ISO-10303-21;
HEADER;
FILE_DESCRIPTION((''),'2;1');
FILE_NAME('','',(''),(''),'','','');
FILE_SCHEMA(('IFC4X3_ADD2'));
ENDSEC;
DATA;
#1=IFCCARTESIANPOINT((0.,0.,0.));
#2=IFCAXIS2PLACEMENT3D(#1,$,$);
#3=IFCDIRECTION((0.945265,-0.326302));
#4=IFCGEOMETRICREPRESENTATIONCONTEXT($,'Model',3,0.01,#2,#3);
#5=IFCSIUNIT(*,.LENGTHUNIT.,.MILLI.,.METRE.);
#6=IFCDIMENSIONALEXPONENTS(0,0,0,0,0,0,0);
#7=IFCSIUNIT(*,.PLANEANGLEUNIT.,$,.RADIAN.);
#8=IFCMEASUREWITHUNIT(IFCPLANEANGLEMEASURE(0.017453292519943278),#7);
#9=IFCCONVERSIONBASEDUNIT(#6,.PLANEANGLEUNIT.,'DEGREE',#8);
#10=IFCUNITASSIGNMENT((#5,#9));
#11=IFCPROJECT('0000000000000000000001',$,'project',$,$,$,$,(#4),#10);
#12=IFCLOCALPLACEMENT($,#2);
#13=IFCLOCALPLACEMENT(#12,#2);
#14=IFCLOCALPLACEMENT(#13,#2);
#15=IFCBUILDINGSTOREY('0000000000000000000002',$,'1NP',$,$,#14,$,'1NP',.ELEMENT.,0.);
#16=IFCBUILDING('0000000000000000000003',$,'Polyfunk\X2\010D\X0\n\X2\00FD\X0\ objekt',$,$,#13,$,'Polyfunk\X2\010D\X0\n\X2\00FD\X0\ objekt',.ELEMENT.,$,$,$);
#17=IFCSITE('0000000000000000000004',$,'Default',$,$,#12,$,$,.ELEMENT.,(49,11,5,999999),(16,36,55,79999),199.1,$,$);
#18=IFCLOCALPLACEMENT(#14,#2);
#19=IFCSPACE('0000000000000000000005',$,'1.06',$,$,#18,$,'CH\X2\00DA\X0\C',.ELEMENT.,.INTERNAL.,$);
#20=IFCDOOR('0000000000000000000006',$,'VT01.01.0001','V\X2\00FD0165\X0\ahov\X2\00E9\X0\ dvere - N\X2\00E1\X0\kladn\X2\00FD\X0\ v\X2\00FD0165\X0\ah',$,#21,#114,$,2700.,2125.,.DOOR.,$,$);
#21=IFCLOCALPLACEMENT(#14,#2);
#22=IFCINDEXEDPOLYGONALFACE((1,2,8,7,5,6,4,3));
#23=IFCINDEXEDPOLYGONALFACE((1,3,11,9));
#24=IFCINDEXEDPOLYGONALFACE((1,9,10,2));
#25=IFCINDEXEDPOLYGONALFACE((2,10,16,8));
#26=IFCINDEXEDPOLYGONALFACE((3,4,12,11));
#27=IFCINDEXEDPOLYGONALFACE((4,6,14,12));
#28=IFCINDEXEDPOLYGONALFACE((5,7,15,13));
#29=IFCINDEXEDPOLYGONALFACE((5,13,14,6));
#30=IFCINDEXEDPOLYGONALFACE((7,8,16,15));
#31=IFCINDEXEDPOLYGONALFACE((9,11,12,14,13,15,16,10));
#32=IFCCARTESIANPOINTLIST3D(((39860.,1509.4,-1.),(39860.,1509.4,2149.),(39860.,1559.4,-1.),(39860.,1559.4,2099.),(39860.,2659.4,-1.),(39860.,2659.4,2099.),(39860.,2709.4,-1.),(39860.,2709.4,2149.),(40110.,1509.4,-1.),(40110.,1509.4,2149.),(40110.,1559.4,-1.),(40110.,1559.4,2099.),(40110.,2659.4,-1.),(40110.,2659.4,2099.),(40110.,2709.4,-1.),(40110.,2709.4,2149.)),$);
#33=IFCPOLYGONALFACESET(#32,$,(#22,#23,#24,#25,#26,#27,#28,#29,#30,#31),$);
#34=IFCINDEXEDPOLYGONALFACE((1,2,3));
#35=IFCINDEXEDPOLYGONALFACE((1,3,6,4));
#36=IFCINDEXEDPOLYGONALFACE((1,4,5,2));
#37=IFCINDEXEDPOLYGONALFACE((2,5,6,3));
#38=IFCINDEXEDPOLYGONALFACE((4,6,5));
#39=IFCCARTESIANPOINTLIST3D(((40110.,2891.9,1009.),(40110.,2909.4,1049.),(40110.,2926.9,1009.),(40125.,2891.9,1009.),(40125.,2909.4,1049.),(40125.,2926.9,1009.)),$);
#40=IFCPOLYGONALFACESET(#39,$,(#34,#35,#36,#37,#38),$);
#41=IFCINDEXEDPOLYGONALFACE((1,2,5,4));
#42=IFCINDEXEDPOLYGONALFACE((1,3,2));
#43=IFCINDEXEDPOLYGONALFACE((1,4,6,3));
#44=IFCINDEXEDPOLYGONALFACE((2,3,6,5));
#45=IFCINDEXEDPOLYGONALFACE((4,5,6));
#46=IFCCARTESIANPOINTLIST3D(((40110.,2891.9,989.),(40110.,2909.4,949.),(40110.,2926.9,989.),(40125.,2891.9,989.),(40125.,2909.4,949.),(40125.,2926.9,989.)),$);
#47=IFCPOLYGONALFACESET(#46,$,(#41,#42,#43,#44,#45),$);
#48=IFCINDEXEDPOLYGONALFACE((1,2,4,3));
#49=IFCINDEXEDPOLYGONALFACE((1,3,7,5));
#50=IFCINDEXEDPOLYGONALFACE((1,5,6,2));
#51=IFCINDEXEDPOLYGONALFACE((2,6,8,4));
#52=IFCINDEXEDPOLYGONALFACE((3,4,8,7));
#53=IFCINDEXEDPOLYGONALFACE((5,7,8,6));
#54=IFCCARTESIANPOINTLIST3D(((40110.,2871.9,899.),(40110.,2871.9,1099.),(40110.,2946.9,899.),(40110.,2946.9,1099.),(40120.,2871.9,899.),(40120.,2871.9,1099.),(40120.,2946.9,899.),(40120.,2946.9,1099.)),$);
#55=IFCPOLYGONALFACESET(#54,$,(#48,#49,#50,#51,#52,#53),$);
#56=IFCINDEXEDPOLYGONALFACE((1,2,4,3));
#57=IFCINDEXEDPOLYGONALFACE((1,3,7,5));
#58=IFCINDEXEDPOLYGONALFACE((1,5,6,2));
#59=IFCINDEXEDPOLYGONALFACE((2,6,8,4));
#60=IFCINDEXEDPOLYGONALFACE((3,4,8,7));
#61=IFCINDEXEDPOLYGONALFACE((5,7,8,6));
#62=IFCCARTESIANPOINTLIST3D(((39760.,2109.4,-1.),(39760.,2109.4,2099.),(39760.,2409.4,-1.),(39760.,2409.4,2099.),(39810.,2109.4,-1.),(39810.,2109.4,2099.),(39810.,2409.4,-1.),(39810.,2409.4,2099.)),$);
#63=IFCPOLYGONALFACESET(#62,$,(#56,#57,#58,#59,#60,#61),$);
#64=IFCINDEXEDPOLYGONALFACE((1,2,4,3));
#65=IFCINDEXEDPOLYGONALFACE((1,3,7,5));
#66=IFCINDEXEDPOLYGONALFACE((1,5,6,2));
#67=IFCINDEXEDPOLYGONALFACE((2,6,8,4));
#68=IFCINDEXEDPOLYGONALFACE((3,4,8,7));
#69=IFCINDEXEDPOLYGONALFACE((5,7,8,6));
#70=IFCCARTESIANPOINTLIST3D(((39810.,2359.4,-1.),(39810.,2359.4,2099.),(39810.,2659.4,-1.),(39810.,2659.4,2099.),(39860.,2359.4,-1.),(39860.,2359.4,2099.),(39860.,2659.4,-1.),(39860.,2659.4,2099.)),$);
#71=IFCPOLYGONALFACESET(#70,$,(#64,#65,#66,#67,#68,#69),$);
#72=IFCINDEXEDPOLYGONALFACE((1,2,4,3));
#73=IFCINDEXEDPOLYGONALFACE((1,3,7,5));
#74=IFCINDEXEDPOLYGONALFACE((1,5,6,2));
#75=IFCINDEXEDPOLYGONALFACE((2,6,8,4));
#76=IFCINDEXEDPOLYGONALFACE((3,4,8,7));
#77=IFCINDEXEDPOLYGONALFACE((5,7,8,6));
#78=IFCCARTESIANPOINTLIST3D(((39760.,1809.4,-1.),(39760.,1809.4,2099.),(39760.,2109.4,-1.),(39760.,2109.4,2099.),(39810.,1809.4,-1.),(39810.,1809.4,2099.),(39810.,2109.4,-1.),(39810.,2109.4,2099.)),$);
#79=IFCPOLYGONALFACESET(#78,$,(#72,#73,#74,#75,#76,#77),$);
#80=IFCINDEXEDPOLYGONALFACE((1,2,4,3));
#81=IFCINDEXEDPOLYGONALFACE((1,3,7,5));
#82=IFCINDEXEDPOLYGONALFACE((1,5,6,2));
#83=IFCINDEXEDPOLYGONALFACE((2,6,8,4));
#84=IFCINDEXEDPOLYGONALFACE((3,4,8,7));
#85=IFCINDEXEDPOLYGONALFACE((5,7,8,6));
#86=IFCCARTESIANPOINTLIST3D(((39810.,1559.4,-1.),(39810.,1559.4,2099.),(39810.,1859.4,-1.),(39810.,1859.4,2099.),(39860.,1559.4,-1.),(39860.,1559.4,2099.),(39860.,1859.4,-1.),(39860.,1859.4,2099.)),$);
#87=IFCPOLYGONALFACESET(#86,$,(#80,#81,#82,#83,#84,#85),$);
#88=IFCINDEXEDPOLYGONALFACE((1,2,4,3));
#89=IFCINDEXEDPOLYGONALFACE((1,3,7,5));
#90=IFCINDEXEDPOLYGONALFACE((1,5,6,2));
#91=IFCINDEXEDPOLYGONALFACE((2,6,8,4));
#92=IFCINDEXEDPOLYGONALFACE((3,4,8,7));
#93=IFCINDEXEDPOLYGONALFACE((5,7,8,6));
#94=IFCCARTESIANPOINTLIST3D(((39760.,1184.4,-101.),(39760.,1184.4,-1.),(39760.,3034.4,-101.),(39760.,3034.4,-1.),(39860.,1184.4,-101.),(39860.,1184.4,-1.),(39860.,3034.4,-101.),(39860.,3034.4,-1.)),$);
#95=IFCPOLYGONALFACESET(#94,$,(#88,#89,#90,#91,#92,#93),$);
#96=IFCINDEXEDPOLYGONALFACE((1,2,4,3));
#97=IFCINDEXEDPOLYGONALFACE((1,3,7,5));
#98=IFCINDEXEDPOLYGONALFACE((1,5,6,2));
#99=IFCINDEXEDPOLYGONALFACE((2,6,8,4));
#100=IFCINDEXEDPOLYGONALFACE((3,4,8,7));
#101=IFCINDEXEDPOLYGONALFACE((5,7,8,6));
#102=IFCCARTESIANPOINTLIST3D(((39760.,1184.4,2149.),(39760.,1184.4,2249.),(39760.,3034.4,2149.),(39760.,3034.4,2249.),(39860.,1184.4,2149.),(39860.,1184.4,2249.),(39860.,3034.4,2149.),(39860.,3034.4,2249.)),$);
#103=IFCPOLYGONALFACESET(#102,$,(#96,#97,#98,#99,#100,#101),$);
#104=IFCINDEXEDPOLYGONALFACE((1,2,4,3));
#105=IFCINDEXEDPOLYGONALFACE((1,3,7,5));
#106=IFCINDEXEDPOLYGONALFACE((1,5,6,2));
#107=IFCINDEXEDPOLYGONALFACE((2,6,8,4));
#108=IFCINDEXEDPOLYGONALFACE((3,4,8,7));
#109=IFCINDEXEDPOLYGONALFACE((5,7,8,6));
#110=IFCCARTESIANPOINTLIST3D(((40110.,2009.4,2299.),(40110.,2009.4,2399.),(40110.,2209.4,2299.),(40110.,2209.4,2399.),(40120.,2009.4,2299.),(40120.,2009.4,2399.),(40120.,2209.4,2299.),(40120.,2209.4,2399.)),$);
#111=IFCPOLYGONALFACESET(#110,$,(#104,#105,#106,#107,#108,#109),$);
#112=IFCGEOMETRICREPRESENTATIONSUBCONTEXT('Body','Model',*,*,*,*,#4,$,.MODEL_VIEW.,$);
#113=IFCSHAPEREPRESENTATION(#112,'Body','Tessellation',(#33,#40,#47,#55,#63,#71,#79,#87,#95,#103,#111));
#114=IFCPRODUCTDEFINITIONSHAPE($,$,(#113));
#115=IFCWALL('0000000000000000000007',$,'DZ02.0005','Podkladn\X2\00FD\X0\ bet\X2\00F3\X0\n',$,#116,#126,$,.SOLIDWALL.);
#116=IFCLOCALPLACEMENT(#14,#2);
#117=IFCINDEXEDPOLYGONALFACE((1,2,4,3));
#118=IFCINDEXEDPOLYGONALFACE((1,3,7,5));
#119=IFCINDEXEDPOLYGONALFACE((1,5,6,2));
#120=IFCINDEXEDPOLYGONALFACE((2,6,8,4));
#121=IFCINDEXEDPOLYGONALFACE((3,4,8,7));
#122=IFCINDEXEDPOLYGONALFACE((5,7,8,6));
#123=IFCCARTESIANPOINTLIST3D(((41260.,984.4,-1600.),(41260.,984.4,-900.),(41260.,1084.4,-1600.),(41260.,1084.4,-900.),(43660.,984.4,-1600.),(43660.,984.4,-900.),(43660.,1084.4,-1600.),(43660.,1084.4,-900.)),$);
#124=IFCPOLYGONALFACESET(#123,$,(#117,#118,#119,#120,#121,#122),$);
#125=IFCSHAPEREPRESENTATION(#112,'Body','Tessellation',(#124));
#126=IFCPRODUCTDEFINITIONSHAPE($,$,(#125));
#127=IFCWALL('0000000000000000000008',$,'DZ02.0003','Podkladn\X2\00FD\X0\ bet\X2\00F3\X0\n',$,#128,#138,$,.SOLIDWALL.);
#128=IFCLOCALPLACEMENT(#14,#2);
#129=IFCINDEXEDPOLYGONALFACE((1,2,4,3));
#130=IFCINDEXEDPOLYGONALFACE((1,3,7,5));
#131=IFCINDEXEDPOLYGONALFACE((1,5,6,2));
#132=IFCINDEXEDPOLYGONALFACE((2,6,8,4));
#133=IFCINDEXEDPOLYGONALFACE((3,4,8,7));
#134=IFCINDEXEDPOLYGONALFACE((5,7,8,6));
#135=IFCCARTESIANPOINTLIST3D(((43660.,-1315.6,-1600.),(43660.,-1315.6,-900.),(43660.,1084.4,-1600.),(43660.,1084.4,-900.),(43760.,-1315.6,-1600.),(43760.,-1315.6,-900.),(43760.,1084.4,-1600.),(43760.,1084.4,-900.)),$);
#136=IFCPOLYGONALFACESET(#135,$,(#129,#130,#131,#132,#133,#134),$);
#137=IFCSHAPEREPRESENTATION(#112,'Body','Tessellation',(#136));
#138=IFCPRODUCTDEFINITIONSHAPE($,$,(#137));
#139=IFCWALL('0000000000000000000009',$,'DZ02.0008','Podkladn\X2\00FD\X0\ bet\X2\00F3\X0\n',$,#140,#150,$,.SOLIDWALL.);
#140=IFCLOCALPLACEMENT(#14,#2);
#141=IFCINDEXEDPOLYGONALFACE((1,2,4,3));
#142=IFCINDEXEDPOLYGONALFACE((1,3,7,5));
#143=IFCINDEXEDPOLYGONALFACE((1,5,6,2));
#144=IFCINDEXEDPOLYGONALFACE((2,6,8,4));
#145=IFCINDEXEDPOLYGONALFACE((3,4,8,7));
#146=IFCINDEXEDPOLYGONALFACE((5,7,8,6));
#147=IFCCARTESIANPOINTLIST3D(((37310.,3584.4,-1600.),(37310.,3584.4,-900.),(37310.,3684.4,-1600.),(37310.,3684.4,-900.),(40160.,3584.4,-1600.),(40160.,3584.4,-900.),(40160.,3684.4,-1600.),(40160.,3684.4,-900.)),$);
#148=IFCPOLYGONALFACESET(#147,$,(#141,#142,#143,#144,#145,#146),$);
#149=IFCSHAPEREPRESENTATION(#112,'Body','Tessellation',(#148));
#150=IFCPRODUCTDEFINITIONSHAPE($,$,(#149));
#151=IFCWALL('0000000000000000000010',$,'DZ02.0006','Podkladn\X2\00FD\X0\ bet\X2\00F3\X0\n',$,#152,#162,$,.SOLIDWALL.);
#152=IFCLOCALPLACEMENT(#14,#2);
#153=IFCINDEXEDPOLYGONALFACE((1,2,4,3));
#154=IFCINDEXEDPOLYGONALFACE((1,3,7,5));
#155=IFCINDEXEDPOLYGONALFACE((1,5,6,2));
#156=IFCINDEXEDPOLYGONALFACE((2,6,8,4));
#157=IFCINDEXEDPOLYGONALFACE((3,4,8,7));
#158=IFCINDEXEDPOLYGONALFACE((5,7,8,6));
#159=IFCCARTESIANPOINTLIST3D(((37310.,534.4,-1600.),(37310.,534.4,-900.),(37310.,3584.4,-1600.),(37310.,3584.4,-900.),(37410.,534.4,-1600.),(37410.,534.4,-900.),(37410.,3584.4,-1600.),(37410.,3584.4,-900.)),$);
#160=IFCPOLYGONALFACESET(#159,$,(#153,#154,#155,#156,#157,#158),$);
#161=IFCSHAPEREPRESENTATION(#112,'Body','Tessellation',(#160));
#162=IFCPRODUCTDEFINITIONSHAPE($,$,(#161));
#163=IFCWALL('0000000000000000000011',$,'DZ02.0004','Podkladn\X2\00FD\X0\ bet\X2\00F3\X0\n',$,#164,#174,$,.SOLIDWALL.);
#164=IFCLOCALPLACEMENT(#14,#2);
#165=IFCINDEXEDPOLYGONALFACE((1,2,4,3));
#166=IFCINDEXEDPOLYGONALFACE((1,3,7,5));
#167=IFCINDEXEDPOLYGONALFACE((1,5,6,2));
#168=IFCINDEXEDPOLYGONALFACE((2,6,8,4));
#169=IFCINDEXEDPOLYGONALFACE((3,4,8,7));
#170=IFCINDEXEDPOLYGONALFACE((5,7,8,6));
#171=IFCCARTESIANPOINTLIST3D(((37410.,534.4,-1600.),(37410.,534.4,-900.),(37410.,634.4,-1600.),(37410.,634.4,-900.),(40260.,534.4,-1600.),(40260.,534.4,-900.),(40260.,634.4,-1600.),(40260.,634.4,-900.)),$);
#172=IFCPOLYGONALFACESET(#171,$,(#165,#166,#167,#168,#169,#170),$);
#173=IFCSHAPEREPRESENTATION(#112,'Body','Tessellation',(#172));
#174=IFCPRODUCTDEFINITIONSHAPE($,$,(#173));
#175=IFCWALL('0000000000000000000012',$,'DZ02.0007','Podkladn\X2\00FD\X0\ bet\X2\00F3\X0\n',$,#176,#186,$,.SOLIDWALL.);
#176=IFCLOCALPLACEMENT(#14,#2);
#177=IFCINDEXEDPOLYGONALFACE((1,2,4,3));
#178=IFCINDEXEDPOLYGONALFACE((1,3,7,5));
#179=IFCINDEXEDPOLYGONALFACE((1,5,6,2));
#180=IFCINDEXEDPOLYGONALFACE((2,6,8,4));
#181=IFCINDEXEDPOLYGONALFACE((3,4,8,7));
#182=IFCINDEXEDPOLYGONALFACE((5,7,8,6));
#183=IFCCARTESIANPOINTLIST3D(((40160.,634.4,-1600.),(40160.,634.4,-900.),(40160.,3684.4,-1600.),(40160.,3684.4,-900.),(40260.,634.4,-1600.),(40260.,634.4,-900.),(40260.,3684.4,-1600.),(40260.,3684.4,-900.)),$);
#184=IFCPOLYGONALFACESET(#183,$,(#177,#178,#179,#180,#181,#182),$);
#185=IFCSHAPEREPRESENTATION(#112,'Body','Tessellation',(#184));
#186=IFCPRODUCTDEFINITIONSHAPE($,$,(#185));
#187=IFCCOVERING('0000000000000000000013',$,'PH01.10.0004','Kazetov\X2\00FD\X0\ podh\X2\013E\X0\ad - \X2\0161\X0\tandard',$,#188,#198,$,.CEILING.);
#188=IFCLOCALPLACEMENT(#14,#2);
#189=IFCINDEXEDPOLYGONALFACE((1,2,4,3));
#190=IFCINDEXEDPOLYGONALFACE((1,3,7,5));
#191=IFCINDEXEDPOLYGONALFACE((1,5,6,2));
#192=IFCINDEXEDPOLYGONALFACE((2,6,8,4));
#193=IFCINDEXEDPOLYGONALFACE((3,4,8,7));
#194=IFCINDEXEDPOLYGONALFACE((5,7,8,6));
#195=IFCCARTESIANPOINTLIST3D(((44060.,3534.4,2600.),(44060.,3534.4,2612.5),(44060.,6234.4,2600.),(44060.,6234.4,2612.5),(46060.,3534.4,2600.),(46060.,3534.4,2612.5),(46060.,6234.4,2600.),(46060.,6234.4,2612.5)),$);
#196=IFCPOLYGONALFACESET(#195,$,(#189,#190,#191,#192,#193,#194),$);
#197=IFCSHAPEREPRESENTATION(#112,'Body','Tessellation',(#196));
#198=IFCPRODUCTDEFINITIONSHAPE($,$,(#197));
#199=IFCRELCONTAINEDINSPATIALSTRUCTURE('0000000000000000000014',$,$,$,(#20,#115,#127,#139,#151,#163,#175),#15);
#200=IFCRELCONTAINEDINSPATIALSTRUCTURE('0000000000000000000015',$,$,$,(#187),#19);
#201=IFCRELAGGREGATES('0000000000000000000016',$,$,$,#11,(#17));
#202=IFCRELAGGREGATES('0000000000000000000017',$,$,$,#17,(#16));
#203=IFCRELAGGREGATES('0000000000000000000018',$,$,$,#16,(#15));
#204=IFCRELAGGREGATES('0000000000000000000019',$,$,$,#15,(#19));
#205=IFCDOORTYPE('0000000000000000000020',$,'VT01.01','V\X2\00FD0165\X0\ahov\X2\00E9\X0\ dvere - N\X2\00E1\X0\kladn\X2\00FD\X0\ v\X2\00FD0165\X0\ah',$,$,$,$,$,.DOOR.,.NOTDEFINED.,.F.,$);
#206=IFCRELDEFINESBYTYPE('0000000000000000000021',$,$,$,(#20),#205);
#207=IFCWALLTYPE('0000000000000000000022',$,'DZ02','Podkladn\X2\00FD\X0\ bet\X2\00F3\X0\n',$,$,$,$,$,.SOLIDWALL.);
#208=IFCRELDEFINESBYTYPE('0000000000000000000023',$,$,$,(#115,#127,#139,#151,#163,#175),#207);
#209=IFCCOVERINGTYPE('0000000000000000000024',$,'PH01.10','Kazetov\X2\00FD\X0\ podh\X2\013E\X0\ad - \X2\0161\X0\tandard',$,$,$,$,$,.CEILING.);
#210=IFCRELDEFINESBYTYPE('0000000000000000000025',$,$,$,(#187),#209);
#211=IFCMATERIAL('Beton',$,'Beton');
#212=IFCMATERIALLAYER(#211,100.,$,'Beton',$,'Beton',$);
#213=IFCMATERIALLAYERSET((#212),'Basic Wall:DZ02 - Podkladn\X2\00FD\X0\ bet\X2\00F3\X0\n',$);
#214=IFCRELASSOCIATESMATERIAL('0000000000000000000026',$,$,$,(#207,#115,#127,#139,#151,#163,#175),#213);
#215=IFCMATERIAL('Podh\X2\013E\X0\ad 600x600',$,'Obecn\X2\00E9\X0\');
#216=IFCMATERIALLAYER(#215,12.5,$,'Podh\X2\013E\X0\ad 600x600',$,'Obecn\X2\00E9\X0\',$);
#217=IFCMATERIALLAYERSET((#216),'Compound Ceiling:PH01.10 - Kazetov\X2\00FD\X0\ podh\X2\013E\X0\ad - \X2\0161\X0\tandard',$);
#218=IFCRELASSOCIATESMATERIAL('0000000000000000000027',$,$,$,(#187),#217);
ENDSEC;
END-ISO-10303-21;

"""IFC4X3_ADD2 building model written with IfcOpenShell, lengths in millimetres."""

from ifc_helpers import new_model, entity, si_unit, converted_unit, direction, frame, frame_2d, origin, origin_2d_with_axis, place, context, subcontext, project, spatial, polyline, rectangle, outline, extrude, source, transform, mapped, material, layer, layer_set, layer_usage, type_object, type_shapes, element, save


model = new_model("IFC4X3_ADD2")

# Units and contexts
model_context = context("Model", 3, precision=0.01, world=origin(), true_north=direction((0.945265, -0.326302)))
body_context = subcontext(model_context, "Body", "Model", "MODEL_VIEW")
ifc_project = project(units=[si_unit("LENGTHUNIT", "METRE", prefix="MILLI"), converted_unit("PLANEANGLEUNIT", "DEGREE", entity("IfcPlaneAngleMeasure", 0.017453292519943278), si_unit("PLANEANGLEUNIT", "RADIAN"), dimensions=[0, 0, 0, 0, 0, 0, 0])], contexts=[model_context])

# Site, building, storey
site_placement = place(None, origin())
site = spatial("IfcSite", under=ifc_project, at=site_placement, Name="Default", CompositionType="ELEMENT", RefLatitude=(49, 11, 5, 999999), RefLongitude=(16, 36, 55, 79999), RefElevation=199.1)
building_placement = place(site_placement, origin())
building = spatial("IfcBuilding", under=site, at=building_placement, Name="Polyfunkčný objekt", LongName="Polyfunkčný objekt", CompositionType="ELEMENT")
storey_placement = place(building_placement, origin())
storey = spatial("IfcBuildingStorey", under=building, at=storey_placement, Name="1NP", LongName="1NP", CompositionType="ELEMENT", Elevation=0.0)

# Door
door_type_1 = type_object("IfcDoorType", Name="VT01.01", Description="Výťahové dvere - Nákladný výťah", OperationType="NOTDEFINED", ParameterTakesPrecedence=False, PredefinedType="DOOR")
shared_shape_1 = source(origin(), body_context, "Body", "SweptSolid", [
    extrude(outline(polyline([(-1087.5, -600.0), (1062.5, -600.0), (1062.5, -550.0), (-1037.5, -550.0), (-1037.5, 550.0), (1062.5, 550.0), (1062.5, 600.0), (-1087.5, 600.0), (-1087.5, -600.0)])), frame((600.0, 0.0, 1062.5), z_axis=(0.0, 1.0, 0.0), x_axis=(0.0, 0.0, -1.0)), (0.0, 0.0, 1.0), 250.0),
    extrude(outline(polyline([(-24.4, -10.7), (19.2, -10.7), (5.2, 21.4), (-24.4, -10.7)])), frame((1400.0, -15.0, 1023.3), z_axis=(0.0, 1.0, 0.0), x_axis=(0.400819, 0.0, -0.916157)), (0.0, 0.0, 1.0), 15.0),
    extrude(outline(polyline([(-24.4, -10.7), (19.2, -10.7), (5.2, 21.4), (-24.4, -10.7)])), frame((1400.0, -15.0, 976.7), z_axis=(0.0, 1.0, 0.0), x_axis=(-0.400819, 0.0, 0.916157)), (0.0, 0.0, 1.0), 15.0),
    extrude(rectangle(XDim=10.0, YDim=75.0, at=frame_2d((0.0, 0.0), x_axis=(1.0, 0.0))), frame((1400.0, -5.0, 900.0), z_axis=(0.0, 0.0, 1.0), x_axis=(0.0, 1.0, 0.0)), (0.0, 0.0, 1.0), 200.0),
    extrude(rectangle(XDim=50.0, YDim=300.0, at=origin_2d_with_axis()), frame((750.0, 325.0, 0.0), z_axis=(0.0, 0.0, 1.0), x_axis=(0.0, -1.0, 0.0)), (0.0, 0.0, 1.0), 2100.0),
    extrude(rectangle(XDim=50.0, YDim=300.0, at=frame_2d((0.0, 0.0), x_axis=(1.0, 0.0))), frame((1000.0, 275.0, 0.0), z_axis=(0.0, 0.0, 1.0), x_axis=(0.0, -1.0, 0.0)), (0.0, 0.0, 1.0), 2100.0),
    extrude(rectangle(XDim=300.0, YDim=50.0, at=frame_2d((0.0, 0.0), x_axis=(1.0, 0.0))), frame((450.0, 325.0, 0.0), z_axis=(0.0, 0.0, 1.0), x_axis=(-1.0, 0.0, 0.0)), (0.0, 0.0, 1.0), 2100.0),
    extrude(rectangle(XDim=300.0, YDim=50.0, at=frame_2d((0.0, 0.0), x_axis=(1.0, 0.0))), frame((200.0, 275.0, 0.0), z_axis=(0.0, 0.0, 1.0), x_axis=(-1.0, 0.0, 0.0)), (0.0, 0.0, 1.0), 2100.0),
    extrude(rectangle(XDim=1850.0, YDim=100.0, at=frame_2d((0.0, 0.0), x_axis=(1.0, 0.0))), frame((600.0, 300.0, -100.0), z_axis=(0.0, 0.0, 1.0), x_axis=(-1.0, 0.0, 0.0)), (0.0, 0.0, 1.0), 100.0),
    extrude(rectangle(XDim=1850.0, YDim=100.0, at=frame_2d((0.0, 0.0), x_axis=(1.0, 0.0))), frame((600.0, 300.0, 2150.0), z_axis=(0.0, 0.0, 1.0), x_axis=(-1.0, 0.0, 0.0)), (0.0, 0.0, 1.0), 100.0),
    extrude(rectangle(XDim=10.0, YDim=200.0, at=frame_2d((0.0, 0.0), x_axis=(1.0, 0.0))), frame((600.0, -5.0, 2300.0), z_axis=(0.0, 0.0, 1.0), x_axis=(0.0, 1.0, 0.0)), (0.0, 0.0, 1.0), 100.0),
])
type_shapes(door_type_1, [shared_shape_1])
door_1_placement = place(storey_placement, frame((40110.0, 1509.4, -1.0), z_axis=(0.0, 0.0, 1.0), x_axis=(0.0, 1.0, 0.0)))
element("IfcDoor", 1, at=door_1_placement, inside=storey, type_object=door_type_1, Name="VT01.01.0001", Description="Výťahové dvere - Nákladný výťah", OverallHeight=2700.0, OverallWidth=2125.0, PredefinedType="DOOR", context=body_context, shape_type="MappedRepresentation", body=[
    mapped(shared_shape_1, transform((0.0, 0.0, 0.0), scale=1.0)),
])

# Walls
ifc_material_1 = material(Name="Beton", Category="Beton")
ifc_layer_1 = layer(ifc_material_1, 100.0, Name="Beton", Category="Beton")
ifc_layer_set_1 = layer_set([ifc_layer_1], Name="Basic Wall:DZ02 - Podkladný betón")
wall_type_1 = type_object("IfcWallType", Name="DZ02", Description="Podkladný betón", PredefinedType="SOLIDWALL", material=ifc_layer_set_1)
wall_1_placement = place(storey_placement, frame((41260.0, 1034.4, -1600.0)))
element("IfcWall", 2, at=wall_1_placement, inside=storey, type_object=wall_type_1, material=ifc_layer_set_1, Name="DZ02.0005", Description="Podkladný betón", PredefinedType="SOLIDWALL", context=body_context, shape_type="SweptSolid", body=[
    extrude(rectangle(XDim=2400.0, YDim=100.0, at=frame_2d((1200.0, 0.0), x_axis=(-1.0, 0.0))), origin(), (0.0, 0.0, 1.0), 700.0),
])
wall_2_placement = place(storey_placement, frame((43710.0, 1084.4, -1600.0), z_axis=(0.0, 0.0, 1.0), x_axis=(0.0, -1.0, 0.0)))
element("IfcWall", 3, at=wall_2_placement, inside=storey, type_object=wall_type_1, material=ifc_layer_set_1, Name="DZ02.0003", Description="Podkladný betón", PredefinedType="SOLIDWALL", context=body_context, shape_type="SweptSolid", body=[
    extrude(rectangle(XDim=2400.0, YDim=100.0, at=frame_2d((1200.0, 0.0), x_axis=(-1.0, 0.0))), origin(), (0.0, 0.0, 1.0), 700.0),
])
wall_3_placement = place(storey_placement, frame((37310.0, 3634.4, -1600.0)))
element("IfcWall", 4, at=wall_3_placement, inside=storey, type_object=wall_type_1, material=ifc_layer_set_1, Name="DZ02.0008", Description="Podkladný betón", PredefinedType="SOLIDWALL", context=body_context, shape_type="SweptSolid", body=[
    extrude(rectangle(XDim=2850.0, YDim=100.0, at=frame_2d((1425.0, 0.0), x_axis=(-1.0, 0.0))), origin(), (0.0, 0.0, 1.0), 700.0),
])
wall_4_placement = place(storey_placement, frame((37360.0, 534.4, -1600.0), z_axis=(0.0, 0.0, 1.0), x_axis=(0.0, 1.0, 0.0)))
element("IfcWall", 5, at=wall_4_placement, inside=storey, type_object=wall_type_1, material=ifc_layer_set_1, Name="DZ02.0006", Description="Podkladný betón", PredefinedType="SOLIDWALL", context=body_context, shape_type="SweptSolid", body=[
    extrude(rectangle(XDim=3050.0, YDim=100.0, at=frame_2d((1525.0, 0.0), x_axis=(-1.0, 0.0))), origin(), (0.0, 0.0, 1.0), 700.0),
])
wall_5_placement = place(storey_placement, frame((40260.0, 584.4, -1600.0), z_axis=(0.0, 0.0, 1.0), x_axis=(-1.0, 0.0, 0.0)))
element("IfcWall", 6, at=wall_5_placement, inside=storey, type_object=wall_type_1, material=ifc_layer_set_1, Name="DZ02.0004", Description="Podkladný betón", PredefinedType="SOLIDWALL", context=body_context, shape_type="SweptSolid", body=[
    extrude(rectangle(XDim=2850.0, YDim=100.0, at=frame_2d((1425.0, 0.0), x_axis=(-1.0, 0.0))), origin(), (0.0, 0.0, 1.0), 700.0),
])
wall_6_placement = place(storey_placement, frame((40210.0, 3684.4, -1600.0), z_axis=(0.0, 0.0, 1.0), x_axis=(0.0, -1.0, 0.0)))
element("IfcWall", 7, at=wall_6_placement, inside=storey, type_object=wall_type_1, material=ifc_layer_set_1, Name="DZ02.0007", Description="Podkladný betón", PredefinedType="SOLIDWALL", context=body_context, shape_type="SweptSolid", body=[
    extrude(rectangle(XDim=3050.0, YDim=100.0, at=frame_2d((1525.0, 0.0), x_axis=(-1.0, 0.0))), origin(), (0.0, 0.0, 1.0), 700.0),
])

# Shared definitions
space_1_placement = place(storey_placement, origin())
space_1 = spatial("IfcSpace", under=storey, at=space_1_placement, Name="1.06", LongName="CHÚC", CompositionType="ELEMENT", PredefinedType="INTERNAL")

# Covering
ifc_material_2 = material(Name="Podhľad 600x600", Category="Obecné")
ifc_layer_2 = layer(ifc_material_2, 12.5, Name="Podhľad 600x600", Category="Obecné")
ifc_layer_set_2 = layer_set([ifc_layer_2], Name="Compound Ceiling:PH01.10 - Kazetový podhľad - štandard")
ifc_layer_usage_1 = layer_usage(ifc_layer_set_2, "AXIS3", "NEGATIVE", 0.0)
covering_type_1 = type_object("IfcCoveringType", Name="PH01.10", Description="Kazetový podhľad - štandard", PredefinedType="CEILING")
covering_1_placement = place(storey_placement, frame((44060.0, 3534.4, 2600.0)))
element("IfcCovering", 8, at=covering_1_placement, inside=space_1, type_object=covering_type_1, material=ifc_layer_usage_1, Name="PH01.10.0004", Description="Kazetový podhľad - štandard", PredefinedType="CEILING", context=body_context, shape_type="SweptSolid", body=[
    extrude(rectangle(XDim=2000.0, YDim=2700.0, at=frame_2d((0.0, 0.0), x_axis=(1.0, 0.0))), frame((1000.0, 1350.0, 0.0)), (0.0, 0.0, 1.0), 12.5),
])

save(model, "model.ifc")
